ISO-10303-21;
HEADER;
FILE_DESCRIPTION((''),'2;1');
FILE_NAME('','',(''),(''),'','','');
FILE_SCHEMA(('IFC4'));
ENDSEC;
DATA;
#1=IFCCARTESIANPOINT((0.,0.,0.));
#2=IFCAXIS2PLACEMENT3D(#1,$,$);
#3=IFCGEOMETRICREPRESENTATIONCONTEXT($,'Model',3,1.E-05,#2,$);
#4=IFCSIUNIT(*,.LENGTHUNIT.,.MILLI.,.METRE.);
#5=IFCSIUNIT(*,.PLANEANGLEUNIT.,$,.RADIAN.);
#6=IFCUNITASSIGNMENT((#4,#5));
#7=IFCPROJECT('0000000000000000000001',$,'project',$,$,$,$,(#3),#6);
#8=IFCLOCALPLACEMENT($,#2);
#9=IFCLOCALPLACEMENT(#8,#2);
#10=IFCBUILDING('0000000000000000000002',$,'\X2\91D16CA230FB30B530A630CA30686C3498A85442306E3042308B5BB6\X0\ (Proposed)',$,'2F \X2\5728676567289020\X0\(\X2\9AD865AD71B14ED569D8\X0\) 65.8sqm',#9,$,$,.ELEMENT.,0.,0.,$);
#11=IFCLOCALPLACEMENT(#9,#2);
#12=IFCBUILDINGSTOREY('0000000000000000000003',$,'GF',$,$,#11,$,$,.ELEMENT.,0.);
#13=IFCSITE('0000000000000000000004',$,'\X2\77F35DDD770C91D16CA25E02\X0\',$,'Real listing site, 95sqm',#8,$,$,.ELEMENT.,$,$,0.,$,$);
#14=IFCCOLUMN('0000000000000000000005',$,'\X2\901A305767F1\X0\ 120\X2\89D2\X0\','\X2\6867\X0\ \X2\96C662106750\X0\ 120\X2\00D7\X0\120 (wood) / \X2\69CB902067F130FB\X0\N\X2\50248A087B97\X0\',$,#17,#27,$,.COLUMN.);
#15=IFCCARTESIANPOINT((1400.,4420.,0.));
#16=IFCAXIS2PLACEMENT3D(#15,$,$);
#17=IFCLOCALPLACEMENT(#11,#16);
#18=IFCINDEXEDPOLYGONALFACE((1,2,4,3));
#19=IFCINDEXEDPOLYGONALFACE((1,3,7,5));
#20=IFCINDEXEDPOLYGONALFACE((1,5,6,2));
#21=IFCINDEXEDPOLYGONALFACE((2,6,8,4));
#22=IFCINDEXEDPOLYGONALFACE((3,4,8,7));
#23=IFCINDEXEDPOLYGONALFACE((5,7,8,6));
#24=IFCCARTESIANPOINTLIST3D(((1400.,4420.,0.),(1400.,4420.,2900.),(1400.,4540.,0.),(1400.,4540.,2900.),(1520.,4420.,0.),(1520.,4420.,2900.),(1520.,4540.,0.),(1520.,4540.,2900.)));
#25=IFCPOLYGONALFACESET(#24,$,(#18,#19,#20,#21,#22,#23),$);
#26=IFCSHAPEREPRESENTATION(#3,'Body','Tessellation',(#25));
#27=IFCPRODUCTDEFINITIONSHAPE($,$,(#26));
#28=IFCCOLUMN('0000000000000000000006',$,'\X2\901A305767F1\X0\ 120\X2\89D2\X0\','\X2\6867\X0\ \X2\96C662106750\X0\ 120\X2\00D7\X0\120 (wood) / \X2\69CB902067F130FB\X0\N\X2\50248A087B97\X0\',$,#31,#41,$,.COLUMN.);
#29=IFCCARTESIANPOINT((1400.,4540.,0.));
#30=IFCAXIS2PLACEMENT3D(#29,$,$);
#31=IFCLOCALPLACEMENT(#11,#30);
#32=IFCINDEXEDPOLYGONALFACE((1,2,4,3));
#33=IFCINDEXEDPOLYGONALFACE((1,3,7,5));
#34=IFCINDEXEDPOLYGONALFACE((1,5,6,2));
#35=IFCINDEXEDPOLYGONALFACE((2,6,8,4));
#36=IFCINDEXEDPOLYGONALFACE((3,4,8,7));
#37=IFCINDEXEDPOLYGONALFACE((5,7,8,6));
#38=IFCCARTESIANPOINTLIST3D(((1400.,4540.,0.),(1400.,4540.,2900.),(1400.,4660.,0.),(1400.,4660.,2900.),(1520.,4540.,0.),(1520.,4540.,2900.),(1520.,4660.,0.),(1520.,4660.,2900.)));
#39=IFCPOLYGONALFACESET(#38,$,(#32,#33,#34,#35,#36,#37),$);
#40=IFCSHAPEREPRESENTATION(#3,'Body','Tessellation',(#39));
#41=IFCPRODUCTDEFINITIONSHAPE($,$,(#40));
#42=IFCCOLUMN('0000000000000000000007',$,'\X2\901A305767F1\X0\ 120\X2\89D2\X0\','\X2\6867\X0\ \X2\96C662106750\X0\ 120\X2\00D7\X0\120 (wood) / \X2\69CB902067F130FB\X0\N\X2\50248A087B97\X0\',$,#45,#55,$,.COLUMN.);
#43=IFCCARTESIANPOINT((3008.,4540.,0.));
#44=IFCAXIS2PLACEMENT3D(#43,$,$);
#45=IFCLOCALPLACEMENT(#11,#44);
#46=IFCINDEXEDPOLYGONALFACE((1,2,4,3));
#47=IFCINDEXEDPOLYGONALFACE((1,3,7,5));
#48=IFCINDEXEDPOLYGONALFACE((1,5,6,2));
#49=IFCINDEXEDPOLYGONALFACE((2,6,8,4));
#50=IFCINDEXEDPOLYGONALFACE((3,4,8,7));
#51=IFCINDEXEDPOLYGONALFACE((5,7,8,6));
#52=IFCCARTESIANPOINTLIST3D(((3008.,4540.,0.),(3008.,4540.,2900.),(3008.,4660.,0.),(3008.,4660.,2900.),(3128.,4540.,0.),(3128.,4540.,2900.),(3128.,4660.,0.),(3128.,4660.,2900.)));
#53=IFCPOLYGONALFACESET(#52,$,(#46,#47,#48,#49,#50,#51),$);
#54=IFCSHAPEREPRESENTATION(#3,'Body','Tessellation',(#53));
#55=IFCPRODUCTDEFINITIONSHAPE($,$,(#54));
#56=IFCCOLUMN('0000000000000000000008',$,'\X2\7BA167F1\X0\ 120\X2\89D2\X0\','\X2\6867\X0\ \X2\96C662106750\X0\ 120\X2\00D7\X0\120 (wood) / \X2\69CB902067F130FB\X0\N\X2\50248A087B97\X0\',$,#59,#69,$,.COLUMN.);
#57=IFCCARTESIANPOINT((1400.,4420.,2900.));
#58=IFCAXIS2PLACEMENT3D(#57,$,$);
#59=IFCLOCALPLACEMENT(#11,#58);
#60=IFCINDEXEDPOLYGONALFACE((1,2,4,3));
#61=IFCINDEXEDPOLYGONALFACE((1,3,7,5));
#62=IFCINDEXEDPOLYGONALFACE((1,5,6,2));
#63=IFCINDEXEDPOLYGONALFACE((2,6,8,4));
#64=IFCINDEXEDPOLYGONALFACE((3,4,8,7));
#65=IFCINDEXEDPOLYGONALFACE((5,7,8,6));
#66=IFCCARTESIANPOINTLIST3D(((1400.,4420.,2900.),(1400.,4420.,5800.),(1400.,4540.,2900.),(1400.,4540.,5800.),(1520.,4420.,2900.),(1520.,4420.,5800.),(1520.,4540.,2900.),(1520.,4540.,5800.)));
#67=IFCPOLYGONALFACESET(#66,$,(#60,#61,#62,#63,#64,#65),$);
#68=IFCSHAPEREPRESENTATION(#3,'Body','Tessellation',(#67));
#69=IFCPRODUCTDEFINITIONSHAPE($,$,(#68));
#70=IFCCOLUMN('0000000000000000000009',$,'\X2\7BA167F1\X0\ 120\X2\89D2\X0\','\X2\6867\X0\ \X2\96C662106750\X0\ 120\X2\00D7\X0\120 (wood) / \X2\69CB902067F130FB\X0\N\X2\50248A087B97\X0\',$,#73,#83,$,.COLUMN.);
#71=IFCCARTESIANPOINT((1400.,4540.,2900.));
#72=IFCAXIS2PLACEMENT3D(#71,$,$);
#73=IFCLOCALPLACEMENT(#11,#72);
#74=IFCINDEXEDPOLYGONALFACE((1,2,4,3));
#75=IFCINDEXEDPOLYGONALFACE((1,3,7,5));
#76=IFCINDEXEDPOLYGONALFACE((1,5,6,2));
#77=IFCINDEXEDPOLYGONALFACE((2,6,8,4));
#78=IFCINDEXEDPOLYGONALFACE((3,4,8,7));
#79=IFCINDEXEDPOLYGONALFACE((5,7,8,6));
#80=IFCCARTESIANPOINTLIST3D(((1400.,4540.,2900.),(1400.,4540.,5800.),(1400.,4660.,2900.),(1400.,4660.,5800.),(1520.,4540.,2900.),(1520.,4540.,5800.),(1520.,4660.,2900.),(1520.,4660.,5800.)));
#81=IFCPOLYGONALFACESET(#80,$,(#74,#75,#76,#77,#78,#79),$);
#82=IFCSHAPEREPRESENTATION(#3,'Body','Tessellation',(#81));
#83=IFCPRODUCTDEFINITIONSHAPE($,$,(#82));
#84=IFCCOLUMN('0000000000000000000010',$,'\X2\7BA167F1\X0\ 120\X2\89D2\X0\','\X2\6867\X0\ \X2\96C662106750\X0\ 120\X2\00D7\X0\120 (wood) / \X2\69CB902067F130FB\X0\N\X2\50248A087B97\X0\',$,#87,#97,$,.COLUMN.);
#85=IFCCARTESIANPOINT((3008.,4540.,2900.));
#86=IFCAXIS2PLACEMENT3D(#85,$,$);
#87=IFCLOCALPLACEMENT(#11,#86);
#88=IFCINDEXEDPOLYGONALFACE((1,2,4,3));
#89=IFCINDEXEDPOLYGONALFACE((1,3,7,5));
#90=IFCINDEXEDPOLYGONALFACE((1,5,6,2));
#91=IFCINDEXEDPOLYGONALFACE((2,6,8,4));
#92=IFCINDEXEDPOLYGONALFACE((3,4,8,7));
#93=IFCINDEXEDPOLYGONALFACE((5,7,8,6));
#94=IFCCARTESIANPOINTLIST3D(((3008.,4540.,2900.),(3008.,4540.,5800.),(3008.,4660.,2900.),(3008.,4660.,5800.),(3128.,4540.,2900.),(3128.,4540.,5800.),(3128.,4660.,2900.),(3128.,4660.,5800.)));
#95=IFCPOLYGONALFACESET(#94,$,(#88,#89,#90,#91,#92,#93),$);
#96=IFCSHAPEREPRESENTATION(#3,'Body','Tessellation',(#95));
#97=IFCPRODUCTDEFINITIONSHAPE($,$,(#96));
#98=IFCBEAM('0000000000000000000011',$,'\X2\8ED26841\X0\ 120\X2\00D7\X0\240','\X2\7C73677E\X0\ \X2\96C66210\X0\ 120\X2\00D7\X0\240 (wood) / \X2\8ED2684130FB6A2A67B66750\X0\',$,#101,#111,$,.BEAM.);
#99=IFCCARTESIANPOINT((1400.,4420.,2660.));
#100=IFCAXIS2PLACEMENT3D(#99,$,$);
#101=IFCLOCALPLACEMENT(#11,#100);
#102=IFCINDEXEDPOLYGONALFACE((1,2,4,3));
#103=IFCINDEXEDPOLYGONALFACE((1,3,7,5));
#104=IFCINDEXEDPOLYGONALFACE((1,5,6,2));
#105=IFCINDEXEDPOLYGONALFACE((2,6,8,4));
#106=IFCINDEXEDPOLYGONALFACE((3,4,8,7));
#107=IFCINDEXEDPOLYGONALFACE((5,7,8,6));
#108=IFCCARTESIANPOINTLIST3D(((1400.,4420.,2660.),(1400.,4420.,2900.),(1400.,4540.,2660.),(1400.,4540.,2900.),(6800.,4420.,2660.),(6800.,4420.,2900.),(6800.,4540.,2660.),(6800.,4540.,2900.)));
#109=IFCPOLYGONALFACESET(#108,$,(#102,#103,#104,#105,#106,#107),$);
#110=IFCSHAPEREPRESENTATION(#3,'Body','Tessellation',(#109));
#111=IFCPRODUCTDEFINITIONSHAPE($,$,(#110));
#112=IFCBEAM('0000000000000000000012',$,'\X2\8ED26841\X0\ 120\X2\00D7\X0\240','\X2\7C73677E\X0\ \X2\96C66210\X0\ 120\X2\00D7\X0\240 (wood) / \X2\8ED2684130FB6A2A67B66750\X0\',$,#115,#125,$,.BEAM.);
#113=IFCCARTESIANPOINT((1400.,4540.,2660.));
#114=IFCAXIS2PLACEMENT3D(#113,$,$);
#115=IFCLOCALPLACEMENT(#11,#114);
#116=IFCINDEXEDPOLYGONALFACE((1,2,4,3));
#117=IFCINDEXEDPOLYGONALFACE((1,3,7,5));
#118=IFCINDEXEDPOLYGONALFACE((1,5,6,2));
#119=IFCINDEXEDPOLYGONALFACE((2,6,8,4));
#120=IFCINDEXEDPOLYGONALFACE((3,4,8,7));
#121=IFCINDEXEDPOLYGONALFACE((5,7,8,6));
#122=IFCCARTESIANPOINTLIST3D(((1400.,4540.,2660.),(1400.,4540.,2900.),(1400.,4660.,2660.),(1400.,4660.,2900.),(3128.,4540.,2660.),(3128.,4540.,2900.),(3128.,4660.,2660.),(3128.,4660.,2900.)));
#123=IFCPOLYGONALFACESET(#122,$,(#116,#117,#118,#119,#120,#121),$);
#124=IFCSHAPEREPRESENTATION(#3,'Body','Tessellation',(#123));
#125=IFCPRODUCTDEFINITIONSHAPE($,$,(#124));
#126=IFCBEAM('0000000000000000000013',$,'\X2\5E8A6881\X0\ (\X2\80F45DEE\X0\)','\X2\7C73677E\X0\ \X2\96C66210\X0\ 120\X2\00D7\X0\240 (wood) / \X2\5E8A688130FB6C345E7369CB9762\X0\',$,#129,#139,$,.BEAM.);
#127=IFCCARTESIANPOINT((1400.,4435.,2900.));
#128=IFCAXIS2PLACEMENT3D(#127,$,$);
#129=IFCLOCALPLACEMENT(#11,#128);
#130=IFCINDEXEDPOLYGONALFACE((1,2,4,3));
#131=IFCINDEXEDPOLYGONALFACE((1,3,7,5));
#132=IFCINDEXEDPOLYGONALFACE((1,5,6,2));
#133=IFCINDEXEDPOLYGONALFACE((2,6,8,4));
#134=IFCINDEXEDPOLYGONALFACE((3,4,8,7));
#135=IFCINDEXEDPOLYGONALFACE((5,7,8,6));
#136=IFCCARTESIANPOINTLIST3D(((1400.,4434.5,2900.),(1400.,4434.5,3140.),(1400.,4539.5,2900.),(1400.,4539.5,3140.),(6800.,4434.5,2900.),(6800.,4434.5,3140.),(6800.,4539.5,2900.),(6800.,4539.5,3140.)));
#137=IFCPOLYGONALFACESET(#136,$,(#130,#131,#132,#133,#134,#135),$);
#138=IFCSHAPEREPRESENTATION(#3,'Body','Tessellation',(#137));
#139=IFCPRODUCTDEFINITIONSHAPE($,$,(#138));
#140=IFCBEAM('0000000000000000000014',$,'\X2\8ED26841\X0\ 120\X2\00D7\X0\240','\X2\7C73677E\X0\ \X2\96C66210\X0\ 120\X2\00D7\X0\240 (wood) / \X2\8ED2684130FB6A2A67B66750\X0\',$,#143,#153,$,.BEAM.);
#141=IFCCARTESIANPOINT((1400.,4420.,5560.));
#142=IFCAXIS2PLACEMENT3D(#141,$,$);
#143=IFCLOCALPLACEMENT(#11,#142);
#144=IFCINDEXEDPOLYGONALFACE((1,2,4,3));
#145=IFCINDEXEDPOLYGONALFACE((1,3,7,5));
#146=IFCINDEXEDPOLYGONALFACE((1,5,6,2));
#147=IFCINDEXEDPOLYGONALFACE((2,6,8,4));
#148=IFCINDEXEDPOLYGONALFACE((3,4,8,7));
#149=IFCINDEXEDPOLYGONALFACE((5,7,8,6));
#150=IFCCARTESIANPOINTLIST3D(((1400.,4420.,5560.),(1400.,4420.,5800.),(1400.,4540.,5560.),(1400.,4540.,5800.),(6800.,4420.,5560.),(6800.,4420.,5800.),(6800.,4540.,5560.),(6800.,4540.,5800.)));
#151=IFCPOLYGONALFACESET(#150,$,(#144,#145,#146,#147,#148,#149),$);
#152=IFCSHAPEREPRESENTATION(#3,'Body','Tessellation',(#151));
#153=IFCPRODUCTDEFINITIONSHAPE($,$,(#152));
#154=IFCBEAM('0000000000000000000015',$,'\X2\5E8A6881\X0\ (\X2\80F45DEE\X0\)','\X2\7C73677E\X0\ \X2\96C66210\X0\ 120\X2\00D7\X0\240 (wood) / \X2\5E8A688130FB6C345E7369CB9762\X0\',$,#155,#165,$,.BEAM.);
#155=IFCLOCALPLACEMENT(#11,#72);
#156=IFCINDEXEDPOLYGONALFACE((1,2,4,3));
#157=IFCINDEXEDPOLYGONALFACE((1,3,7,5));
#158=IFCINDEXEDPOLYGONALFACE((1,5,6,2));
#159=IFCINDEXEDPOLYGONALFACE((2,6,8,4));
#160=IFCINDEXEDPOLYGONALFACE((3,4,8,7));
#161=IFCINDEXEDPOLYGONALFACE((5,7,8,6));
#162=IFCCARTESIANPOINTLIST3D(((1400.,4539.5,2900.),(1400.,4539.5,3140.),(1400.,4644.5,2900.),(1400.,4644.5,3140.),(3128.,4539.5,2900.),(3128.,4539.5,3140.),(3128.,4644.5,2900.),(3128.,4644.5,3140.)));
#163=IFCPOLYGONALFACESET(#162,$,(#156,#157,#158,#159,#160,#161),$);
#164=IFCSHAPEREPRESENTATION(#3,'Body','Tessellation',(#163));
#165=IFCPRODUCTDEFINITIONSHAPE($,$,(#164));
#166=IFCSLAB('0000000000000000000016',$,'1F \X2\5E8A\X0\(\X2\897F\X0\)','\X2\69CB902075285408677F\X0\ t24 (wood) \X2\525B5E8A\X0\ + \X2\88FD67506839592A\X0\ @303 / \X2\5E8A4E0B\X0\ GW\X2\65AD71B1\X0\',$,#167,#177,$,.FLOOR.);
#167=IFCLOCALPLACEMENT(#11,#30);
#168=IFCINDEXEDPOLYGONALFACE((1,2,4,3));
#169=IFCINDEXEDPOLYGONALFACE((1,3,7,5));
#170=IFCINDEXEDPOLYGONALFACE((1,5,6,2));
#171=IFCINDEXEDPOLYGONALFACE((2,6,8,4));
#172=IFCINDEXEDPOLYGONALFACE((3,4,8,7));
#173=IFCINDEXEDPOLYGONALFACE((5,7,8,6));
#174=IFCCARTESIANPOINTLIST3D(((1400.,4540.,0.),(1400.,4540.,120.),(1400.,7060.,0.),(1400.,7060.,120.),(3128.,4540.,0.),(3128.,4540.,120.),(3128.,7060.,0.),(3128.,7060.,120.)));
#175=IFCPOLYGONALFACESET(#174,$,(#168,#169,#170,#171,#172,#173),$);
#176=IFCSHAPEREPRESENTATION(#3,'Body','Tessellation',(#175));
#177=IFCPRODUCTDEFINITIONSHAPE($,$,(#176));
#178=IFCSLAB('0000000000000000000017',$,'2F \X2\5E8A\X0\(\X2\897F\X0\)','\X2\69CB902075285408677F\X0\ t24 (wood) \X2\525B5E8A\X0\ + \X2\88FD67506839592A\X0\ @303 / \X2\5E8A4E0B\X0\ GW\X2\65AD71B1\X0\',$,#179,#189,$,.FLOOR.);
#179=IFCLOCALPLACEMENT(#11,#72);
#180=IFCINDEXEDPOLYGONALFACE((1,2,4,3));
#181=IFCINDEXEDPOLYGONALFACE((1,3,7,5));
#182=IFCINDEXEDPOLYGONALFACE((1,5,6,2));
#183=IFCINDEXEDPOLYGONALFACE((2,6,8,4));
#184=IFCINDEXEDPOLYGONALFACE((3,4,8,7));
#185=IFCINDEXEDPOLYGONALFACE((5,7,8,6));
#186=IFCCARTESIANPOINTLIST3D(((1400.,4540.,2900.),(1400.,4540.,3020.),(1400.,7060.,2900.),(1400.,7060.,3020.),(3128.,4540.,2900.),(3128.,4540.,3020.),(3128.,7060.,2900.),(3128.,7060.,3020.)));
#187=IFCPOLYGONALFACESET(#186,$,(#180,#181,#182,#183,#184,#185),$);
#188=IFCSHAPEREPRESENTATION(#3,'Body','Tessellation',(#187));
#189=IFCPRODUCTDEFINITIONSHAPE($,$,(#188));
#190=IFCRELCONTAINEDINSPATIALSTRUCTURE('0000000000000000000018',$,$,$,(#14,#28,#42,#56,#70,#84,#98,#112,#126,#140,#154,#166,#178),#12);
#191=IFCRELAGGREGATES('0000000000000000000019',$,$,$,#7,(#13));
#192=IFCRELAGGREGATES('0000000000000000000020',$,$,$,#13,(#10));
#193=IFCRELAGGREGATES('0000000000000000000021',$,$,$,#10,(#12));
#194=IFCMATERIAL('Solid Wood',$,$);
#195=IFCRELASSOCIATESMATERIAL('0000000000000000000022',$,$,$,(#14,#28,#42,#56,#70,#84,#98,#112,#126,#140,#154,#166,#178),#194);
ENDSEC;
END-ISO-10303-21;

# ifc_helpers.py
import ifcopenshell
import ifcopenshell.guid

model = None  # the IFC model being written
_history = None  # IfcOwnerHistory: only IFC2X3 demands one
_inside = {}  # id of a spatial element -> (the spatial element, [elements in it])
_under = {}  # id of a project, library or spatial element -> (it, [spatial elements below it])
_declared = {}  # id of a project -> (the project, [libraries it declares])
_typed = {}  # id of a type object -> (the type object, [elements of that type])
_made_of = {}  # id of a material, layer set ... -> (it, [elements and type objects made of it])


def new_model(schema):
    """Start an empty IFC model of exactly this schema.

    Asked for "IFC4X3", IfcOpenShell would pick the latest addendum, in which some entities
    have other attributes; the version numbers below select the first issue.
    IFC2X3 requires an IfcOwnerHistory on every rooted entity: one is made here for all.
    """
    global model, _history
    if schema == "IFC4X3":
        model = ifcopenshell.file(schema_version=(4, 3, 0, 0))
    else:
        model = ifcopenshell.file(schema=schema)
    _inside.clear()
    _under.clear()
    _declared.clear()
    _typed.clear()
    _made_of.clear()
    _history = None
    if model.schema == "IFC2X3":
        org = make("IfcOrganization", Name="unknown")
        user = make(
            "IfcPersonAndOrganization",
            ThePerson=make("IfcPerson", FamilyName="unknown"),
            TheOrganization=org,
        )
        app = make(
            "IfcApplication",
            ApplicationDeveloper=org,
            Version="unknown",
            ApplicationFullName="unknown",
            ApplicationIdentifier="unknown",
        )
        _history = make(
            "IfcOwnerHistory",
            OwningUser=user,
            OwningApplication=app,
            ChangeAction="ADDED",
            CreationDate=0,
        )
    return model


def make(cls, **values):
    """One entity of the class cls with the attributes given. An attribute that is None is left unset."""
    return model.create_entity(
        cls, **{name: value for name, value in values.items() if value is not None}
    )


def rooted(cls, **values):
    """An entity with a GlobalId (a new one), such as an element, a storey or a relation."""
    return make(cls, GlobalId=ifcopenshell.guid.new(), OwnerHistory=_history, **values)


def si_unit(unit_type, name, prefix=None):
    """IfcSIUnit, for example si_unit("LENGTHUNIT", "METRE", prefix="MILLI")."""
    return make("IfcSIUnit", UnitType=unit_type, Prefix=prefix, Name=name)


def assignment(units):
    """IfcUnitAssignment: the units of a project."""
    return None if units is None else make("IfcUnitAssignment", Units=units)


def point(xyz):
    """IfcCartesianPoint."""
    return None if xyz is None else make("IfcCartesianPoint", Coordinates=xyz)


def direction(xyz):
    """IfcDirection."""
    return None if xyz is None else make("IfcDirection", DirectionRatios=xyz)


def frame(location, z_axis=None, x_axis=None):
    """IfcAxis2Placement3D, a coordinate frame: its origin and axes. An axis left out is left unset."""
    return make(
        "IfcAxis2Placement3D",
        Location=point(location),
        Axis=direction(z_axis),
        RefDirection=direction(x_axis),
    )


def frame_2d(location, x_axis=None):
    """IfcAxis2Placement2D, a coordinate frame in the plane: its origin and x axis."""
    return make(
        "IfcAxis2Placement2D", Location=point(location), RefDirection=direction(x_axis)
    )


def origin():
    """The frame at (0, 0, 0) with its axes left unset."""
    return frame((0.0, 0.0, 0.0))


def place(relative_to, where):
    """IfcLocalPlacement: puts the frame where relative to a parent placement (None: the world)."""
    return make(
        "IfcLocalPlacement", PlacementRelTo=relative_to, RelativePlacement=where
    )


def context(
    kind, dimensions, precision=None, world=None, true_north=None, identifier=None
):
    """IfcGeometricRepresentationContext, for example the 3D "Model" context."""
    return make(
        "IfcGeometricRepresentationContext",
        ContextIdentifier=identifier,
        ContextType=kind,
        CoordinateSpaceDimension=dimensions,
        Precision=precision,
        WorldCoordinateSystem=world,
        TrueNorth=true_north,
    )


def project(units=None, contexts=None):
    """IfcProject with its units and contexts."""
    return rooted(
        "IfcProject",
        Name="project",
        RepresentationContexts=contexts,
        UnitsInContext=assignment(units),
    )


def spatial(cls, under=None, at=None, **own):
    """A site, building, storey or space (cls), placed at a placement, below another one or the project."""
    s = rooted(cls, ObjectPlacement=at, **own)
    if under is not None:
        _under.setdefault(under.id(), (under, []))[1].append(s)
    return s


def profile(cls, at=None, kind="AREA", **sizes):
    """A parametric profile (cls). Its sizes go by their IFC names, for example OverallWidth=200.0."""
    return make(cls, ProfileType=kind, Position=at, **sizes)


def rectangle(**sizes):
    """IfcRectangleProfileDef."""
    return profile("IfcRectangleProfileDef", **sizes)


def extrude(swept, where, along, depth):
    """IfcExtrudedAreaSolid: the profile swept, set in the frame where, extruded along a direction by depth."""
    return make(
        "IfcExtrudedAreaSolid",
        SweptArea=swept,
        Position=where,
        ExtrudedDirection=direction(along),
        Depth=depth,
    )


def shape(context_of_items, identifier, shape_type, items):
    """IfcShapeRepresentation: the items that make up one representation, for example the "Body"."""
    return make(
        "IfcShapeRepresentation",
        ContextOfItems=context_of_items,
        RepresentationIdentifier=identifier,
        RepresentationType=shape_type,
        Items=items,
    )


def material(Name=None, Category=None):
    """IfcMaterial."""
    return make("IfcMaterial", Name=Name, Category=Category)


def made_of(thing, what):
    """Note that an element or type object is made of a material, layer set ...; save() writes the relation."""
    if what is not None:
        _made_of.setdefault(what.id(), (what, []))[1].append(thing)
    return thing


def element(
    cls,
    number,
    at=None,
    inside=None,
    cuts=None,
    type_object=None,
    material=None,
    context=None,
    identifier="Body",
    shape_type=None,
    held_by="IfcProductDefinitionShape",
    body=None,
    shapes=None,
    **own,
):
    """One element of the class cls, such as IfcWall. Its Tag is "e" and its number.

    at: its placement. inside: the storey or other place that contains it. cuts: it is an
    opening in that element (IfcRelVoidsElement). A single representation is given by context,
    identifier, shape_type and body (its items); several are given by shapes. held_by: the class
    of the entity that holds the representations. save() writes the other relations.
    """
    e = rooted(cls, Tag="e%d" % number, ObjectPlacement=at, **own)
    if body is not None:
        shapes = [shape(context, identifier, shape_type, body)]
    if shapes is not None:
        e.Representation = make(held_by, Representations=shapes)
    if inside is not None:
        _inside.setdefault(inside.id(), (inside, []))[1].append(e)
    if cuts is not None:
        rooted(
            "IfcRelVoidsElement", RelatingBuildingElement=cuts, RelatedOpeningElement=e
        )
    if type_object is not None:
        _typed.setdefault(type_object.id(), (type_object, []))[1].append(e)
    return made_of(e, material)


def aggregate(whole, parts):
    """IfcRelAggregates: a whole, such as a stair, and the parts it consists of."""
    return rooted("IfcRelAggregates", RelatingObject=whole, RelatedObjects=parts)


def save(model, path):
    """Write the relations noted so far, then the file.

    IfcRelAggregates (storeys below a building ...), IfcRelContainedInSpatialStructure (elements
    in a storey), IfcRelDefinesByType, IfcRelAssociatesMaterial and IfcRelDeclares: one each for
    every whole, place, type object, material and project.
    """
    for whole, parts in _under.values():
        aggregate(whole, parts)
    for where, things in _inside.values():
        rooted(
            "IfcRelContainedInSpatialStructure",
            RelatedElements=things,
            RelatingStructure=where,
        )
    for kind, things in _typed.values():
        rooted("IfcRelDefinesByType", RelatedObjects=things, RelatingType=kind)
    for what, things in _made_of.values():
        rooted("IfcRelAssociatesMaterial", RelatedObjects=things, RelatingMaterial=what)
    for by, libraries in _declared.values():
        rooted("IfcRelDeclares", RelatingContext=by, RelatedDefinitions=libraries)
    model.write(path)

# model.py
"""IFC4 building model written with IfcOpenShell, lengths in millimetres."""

from ifc_helpers import new_model, si_unit, frame, frame_2d, origin, place, context, project, spatial, rectangle, extrude, material, element, save


model = new_model("IFC4")

# Units and contexts
model_context = context("Model", 3, precision=1e-05, world=origin())
ifc_project = project(units=[si_unit("LENGTHUNIT", "METRE", prefix="MILLI"), si_unit("PLANEANGLEUNIT", "RADIAN")], contexts=[model_context])

# Site, building, storey
site_placement = place(None, origin())
site = spatial("IfcSite", under=ifc_project, at=site_placement, Name="石川県金沢市", ObjectType="Real listing site, 95sqm", CompositionType="ELEMENT", RefElevation=0.0)
building_placement = place(site_placement, origin())
building = spatial("IfcBuilding", under=site, at=building_placement, Name="金沢・サウナと水風呂のある家 (Proposed)", ObjectType="2F 在来木造(高断熱仕様) 65.8sqm", CompositionType="ELEMENT", ElevationOfRefHeight=0.0, ElevationOfTerrain=0.0)
storey_placement = place(building_placement, origin())
storey = spatial("IfcBuildingStorey", under=building, at=storey_placement, Name="GF", CompositionType="ELEMENT", Elevation=0.0)

# Columns
ifc_material_1 = material(Name="Solid Wood")
column_1_placement = place(storey_placement, frame((1400.0, 4420.0, 0.0)))
element("IfcColumn", 1, at=column_1_placement, inside=storey, material=ifc_material_1, Name="通し柱 120角", Description="桧 集成材 120×120 (wood) / 構造柱・N値計算", PredefinedType="COLUMN", context=model_context, shape_type="SweptSolid", body=[
    extrude(rectangle(XDim=120.0, YDim=120.0, at=frame_2d((60.0, 60.0))), frame((1400.0, 4420.0, 0.0)), (0.0, 0.0, 1.0), 2900.0),
])
column_2_placement = place(storey_placement, frame((1400.0, 4540.0, 0.0)))
element("IfcColumn", 2, at=column_2_placement, inside=storey, material=ifc_material_1, Name="通し柱 120角", Description="桧 集成材 120×120 (wood) / 構造柱・N値計算", PredefinedType="COLUMN", context=model_context, shape_type="SweptSolid", body=[
    extrude(rectangle(XDim=120.0, YDim=120.0, at=frame_2d((60.0, 60.0))), frame((1400.0, 4540.0, 0.0)), (0.0, 0.0, 1.0), 2900.0),
])
column_3_placement = place(storey_placement, frame((3008.0, 4540.0, 0.0)))
element("IfcColumn", 3, at=column_3_placement, inside=storey, material=ifc_material_1, Name="通し柱 120角", Description="桧 集成材 120×120 (wood) / 構造柱・N値計算", PredefinedType="COLUMN", context=model_context, shape_type="SweptSolid", body=[
    extrude(rectangle(XDim=120.0, YDim=120.0, at=frame_2d((60.0, 60.0))), frame((3008.0, 4540.0, 0.0)), (0.0, 0.0, 1.0), 2900.0),
])
column_4_placement = place(storey_placement, frame((1400.0, 4420.0, 2900.0)))
element("IfcColumn", 4, at=column_4_placement, inside=storey, material=ifc_material_1, Name="管柱 120角", Description="桧 集成材 120×120 (wood) / 構造柱・N値計算", PredefinedType="COLUMN", context=model_context, shape_type="SweptSolid", body=[
    extrude(rectangle(XDim=120.0, YDim=120.0, at=frame_2d((60.0, 60.0))), frame((1400.0, 4420.0, 2900.0)), (0.0, 0.0, 1.0), 2900.0),
])
column_5_placement = place(storey_placement, frame((1400.0, 4540.0, 2900.0)))
element("IfcColumn", 5, at=column_5_placement, inside=storey, material=ifc_material_1, Name="管柱 120角", Description="桧 集成材 120×120 (wood) / 構造柱・N値計算", PredefinedType="COLUMN", context=model_context, shape_type="SweptSolid", body=[
    extrude(rectangle(XDim=120.0, YDim=120.0, at=frame_2d((60.0, 60.0))), frame((1400.0, 4540.0, 2900.0)), (0.0, 0.0, 1.0), 2900.0),
])
column_6_placement = place(storey_placement, frame((3008.0, 4540.0, 2900.0)))
element("IfcColumn", 6, at=column_6_placement, inside=storey, material=ifc_material_1, Name="管柱 120角", Description="桧 集成材 120×120 (wood) / 構造柱・N値計算", PredefinedType="COLUMN", context=model_context, shape_type="SweptSolid", body=[
    extrude(rectangle(XDim=120.0, YDim=120.0, at=frame_2d((60.0, 60.0))), frame((3008.0, 4540.0, 2900.0)), (0.0, 0.0, 1.0), 2900.0),
])

# Beams
beam_1_placement = place(storey_placement, frame((1400.0, 4420.0, 2660.0)))
element("IfcBeam", 7, at=beam_1_placement, inside=storey, material=ifc_material_1, Name="軒桁 120×240", Description="米松 集成 120×240 (wood) / 軒桁・横架材", PredefinedType="BEAM", context=model_context, shape_type="SweptSolid", body=[
    extrude(rectangle(XDim=5400.0, YDim=120.0, at=frame_2d((2700.0, 60.0))), frame((1400.0, 4420.0, 2660.0)), (0.0, 0.0, 1.0), 240.0),
])
beam_2_placement = place(storey_placement, frame((1400.0, 4540.0, 2660.0)))
element("IfcBeam", 8, at=beam_2_placement, inside=storey, material=ifc_material_1, Name="軒桁 120×240", Description="米松 集成 120×240 (wood) / 軒桁・横架材", PredefinedType="BEAM", context=model_context, shape_type="SweptSolid", body=[
    extrude(rectangle(XDim=1728.0, YDim=120.0, at=frame_2d((864.0, 60.0))), frame((1400.0, 4540.0, 2660.0)), (0.0, 0.0, 1.0), 240.0),
])
beam_3_placement = place(storey_placement, frame((1400.0, 4435.0, 2900.0)))
element("IfcBeam", 9, at=beam_3_placement, inside=storey, material=ifc_material_1, Name="床梁 (胴差)", Description="米松 集成 120×240 (wood) / 床梁・水平構面", PredefinedType="BEAM", context=model_context, shape_type="SweptSolid", body=[
    extrude(rectangle(XDim=5400.0, YDim=105.0, at=frame_2d((2700.0, 52.0))), frame((1400.0, 4435.0, 2900.0)), (0.0, 0.0, 1.0), 240.0),
])
beam_4_placement = place(storey_placement, frame((1400.0, 4420.0, 5560.0)))
element("IfcBeam", 10, at=beam_4_placement, inside=storey, material=ifc_material_1, Name="軒桁 120×240", Description="米松 集成 120×240 (wood) / 軒桁・横架材", PredefinedType="BEAM", context=model_context, shape_type="SweptSolid", body=[
    extrude(rectangle(XDim=5400.0, YDim=120.0, at=frame_2d((2700.0, 60.0))), frame((1400.0, 4420.0, 5560.0)), (0.0, 0.0, 1.0), 240.0),
])
beam_5_placement = place(storey_placement, frame((1400.0, 4540.0, 2900.0)))
element("IfcBeam", 11, at=beam_5_placement, inside=storey, material=ifc_material_1, Name="床梁 (胴差)", Description="米松 集成 120×240 (wood) / 床梁・水平構面", PredefinedType="BEAM", context=model_context, shape_type="SweptSolid", body=[
    extrude(rectangle(XDim=1728.0, YDim=105.0, at=frame_2d((864.0, 52.0))), frame((1400.0, 4540.0, 2900.0)), (0.0, 0.0, 1.0), 240.0),
])

# Slabs
slab_1_placement = place(storey_placement, frame((1400.0, 4540.0, 0.0)))
element("IfcSlab", 12, at=slab_1_placement, inside=storey, material=ifc_material_1, Name="1F 床(西)", Description="構造用合板 t24 (wood) 剛床 + 製材根太 @303 / 床下 GW断熱", PredefinedType="FLOOR", context=model_context, shape_type="SweptSolid", body=[
    extrude(rectangle(XDim=1728.0, YDim=2520.0, at=frame_2d((864.0, 1260.0))), frame((1400.0, 4540.0, 0.0)), (0.0, 0.0, 1.0), 120.0),
])
slab_2_placement = place(storey_placement, frame((1400.0, 4540.0, 2900.0)))
element("IfcSlab", 13, at=slab_2_placement, inside=storey, material=ifc_material_1, Name="2F 床(西)", Description="構造用合板 t24 (wood) 剛床 + 製材根太 @303 / 床下 GW断熱", PredefinedType="FLOOR", context=model_context, shape_type="SweptSolid", body=[
    extrude(rectangle(XDim=1728.0, YDim=2520.0, at=frame_2d((864.0, 1260.0))), frame((1400.0, 4540.0, 2900.0)), (0.0, 0.0, 1.0), 120.0),
])

save(model, "model.ifc")
